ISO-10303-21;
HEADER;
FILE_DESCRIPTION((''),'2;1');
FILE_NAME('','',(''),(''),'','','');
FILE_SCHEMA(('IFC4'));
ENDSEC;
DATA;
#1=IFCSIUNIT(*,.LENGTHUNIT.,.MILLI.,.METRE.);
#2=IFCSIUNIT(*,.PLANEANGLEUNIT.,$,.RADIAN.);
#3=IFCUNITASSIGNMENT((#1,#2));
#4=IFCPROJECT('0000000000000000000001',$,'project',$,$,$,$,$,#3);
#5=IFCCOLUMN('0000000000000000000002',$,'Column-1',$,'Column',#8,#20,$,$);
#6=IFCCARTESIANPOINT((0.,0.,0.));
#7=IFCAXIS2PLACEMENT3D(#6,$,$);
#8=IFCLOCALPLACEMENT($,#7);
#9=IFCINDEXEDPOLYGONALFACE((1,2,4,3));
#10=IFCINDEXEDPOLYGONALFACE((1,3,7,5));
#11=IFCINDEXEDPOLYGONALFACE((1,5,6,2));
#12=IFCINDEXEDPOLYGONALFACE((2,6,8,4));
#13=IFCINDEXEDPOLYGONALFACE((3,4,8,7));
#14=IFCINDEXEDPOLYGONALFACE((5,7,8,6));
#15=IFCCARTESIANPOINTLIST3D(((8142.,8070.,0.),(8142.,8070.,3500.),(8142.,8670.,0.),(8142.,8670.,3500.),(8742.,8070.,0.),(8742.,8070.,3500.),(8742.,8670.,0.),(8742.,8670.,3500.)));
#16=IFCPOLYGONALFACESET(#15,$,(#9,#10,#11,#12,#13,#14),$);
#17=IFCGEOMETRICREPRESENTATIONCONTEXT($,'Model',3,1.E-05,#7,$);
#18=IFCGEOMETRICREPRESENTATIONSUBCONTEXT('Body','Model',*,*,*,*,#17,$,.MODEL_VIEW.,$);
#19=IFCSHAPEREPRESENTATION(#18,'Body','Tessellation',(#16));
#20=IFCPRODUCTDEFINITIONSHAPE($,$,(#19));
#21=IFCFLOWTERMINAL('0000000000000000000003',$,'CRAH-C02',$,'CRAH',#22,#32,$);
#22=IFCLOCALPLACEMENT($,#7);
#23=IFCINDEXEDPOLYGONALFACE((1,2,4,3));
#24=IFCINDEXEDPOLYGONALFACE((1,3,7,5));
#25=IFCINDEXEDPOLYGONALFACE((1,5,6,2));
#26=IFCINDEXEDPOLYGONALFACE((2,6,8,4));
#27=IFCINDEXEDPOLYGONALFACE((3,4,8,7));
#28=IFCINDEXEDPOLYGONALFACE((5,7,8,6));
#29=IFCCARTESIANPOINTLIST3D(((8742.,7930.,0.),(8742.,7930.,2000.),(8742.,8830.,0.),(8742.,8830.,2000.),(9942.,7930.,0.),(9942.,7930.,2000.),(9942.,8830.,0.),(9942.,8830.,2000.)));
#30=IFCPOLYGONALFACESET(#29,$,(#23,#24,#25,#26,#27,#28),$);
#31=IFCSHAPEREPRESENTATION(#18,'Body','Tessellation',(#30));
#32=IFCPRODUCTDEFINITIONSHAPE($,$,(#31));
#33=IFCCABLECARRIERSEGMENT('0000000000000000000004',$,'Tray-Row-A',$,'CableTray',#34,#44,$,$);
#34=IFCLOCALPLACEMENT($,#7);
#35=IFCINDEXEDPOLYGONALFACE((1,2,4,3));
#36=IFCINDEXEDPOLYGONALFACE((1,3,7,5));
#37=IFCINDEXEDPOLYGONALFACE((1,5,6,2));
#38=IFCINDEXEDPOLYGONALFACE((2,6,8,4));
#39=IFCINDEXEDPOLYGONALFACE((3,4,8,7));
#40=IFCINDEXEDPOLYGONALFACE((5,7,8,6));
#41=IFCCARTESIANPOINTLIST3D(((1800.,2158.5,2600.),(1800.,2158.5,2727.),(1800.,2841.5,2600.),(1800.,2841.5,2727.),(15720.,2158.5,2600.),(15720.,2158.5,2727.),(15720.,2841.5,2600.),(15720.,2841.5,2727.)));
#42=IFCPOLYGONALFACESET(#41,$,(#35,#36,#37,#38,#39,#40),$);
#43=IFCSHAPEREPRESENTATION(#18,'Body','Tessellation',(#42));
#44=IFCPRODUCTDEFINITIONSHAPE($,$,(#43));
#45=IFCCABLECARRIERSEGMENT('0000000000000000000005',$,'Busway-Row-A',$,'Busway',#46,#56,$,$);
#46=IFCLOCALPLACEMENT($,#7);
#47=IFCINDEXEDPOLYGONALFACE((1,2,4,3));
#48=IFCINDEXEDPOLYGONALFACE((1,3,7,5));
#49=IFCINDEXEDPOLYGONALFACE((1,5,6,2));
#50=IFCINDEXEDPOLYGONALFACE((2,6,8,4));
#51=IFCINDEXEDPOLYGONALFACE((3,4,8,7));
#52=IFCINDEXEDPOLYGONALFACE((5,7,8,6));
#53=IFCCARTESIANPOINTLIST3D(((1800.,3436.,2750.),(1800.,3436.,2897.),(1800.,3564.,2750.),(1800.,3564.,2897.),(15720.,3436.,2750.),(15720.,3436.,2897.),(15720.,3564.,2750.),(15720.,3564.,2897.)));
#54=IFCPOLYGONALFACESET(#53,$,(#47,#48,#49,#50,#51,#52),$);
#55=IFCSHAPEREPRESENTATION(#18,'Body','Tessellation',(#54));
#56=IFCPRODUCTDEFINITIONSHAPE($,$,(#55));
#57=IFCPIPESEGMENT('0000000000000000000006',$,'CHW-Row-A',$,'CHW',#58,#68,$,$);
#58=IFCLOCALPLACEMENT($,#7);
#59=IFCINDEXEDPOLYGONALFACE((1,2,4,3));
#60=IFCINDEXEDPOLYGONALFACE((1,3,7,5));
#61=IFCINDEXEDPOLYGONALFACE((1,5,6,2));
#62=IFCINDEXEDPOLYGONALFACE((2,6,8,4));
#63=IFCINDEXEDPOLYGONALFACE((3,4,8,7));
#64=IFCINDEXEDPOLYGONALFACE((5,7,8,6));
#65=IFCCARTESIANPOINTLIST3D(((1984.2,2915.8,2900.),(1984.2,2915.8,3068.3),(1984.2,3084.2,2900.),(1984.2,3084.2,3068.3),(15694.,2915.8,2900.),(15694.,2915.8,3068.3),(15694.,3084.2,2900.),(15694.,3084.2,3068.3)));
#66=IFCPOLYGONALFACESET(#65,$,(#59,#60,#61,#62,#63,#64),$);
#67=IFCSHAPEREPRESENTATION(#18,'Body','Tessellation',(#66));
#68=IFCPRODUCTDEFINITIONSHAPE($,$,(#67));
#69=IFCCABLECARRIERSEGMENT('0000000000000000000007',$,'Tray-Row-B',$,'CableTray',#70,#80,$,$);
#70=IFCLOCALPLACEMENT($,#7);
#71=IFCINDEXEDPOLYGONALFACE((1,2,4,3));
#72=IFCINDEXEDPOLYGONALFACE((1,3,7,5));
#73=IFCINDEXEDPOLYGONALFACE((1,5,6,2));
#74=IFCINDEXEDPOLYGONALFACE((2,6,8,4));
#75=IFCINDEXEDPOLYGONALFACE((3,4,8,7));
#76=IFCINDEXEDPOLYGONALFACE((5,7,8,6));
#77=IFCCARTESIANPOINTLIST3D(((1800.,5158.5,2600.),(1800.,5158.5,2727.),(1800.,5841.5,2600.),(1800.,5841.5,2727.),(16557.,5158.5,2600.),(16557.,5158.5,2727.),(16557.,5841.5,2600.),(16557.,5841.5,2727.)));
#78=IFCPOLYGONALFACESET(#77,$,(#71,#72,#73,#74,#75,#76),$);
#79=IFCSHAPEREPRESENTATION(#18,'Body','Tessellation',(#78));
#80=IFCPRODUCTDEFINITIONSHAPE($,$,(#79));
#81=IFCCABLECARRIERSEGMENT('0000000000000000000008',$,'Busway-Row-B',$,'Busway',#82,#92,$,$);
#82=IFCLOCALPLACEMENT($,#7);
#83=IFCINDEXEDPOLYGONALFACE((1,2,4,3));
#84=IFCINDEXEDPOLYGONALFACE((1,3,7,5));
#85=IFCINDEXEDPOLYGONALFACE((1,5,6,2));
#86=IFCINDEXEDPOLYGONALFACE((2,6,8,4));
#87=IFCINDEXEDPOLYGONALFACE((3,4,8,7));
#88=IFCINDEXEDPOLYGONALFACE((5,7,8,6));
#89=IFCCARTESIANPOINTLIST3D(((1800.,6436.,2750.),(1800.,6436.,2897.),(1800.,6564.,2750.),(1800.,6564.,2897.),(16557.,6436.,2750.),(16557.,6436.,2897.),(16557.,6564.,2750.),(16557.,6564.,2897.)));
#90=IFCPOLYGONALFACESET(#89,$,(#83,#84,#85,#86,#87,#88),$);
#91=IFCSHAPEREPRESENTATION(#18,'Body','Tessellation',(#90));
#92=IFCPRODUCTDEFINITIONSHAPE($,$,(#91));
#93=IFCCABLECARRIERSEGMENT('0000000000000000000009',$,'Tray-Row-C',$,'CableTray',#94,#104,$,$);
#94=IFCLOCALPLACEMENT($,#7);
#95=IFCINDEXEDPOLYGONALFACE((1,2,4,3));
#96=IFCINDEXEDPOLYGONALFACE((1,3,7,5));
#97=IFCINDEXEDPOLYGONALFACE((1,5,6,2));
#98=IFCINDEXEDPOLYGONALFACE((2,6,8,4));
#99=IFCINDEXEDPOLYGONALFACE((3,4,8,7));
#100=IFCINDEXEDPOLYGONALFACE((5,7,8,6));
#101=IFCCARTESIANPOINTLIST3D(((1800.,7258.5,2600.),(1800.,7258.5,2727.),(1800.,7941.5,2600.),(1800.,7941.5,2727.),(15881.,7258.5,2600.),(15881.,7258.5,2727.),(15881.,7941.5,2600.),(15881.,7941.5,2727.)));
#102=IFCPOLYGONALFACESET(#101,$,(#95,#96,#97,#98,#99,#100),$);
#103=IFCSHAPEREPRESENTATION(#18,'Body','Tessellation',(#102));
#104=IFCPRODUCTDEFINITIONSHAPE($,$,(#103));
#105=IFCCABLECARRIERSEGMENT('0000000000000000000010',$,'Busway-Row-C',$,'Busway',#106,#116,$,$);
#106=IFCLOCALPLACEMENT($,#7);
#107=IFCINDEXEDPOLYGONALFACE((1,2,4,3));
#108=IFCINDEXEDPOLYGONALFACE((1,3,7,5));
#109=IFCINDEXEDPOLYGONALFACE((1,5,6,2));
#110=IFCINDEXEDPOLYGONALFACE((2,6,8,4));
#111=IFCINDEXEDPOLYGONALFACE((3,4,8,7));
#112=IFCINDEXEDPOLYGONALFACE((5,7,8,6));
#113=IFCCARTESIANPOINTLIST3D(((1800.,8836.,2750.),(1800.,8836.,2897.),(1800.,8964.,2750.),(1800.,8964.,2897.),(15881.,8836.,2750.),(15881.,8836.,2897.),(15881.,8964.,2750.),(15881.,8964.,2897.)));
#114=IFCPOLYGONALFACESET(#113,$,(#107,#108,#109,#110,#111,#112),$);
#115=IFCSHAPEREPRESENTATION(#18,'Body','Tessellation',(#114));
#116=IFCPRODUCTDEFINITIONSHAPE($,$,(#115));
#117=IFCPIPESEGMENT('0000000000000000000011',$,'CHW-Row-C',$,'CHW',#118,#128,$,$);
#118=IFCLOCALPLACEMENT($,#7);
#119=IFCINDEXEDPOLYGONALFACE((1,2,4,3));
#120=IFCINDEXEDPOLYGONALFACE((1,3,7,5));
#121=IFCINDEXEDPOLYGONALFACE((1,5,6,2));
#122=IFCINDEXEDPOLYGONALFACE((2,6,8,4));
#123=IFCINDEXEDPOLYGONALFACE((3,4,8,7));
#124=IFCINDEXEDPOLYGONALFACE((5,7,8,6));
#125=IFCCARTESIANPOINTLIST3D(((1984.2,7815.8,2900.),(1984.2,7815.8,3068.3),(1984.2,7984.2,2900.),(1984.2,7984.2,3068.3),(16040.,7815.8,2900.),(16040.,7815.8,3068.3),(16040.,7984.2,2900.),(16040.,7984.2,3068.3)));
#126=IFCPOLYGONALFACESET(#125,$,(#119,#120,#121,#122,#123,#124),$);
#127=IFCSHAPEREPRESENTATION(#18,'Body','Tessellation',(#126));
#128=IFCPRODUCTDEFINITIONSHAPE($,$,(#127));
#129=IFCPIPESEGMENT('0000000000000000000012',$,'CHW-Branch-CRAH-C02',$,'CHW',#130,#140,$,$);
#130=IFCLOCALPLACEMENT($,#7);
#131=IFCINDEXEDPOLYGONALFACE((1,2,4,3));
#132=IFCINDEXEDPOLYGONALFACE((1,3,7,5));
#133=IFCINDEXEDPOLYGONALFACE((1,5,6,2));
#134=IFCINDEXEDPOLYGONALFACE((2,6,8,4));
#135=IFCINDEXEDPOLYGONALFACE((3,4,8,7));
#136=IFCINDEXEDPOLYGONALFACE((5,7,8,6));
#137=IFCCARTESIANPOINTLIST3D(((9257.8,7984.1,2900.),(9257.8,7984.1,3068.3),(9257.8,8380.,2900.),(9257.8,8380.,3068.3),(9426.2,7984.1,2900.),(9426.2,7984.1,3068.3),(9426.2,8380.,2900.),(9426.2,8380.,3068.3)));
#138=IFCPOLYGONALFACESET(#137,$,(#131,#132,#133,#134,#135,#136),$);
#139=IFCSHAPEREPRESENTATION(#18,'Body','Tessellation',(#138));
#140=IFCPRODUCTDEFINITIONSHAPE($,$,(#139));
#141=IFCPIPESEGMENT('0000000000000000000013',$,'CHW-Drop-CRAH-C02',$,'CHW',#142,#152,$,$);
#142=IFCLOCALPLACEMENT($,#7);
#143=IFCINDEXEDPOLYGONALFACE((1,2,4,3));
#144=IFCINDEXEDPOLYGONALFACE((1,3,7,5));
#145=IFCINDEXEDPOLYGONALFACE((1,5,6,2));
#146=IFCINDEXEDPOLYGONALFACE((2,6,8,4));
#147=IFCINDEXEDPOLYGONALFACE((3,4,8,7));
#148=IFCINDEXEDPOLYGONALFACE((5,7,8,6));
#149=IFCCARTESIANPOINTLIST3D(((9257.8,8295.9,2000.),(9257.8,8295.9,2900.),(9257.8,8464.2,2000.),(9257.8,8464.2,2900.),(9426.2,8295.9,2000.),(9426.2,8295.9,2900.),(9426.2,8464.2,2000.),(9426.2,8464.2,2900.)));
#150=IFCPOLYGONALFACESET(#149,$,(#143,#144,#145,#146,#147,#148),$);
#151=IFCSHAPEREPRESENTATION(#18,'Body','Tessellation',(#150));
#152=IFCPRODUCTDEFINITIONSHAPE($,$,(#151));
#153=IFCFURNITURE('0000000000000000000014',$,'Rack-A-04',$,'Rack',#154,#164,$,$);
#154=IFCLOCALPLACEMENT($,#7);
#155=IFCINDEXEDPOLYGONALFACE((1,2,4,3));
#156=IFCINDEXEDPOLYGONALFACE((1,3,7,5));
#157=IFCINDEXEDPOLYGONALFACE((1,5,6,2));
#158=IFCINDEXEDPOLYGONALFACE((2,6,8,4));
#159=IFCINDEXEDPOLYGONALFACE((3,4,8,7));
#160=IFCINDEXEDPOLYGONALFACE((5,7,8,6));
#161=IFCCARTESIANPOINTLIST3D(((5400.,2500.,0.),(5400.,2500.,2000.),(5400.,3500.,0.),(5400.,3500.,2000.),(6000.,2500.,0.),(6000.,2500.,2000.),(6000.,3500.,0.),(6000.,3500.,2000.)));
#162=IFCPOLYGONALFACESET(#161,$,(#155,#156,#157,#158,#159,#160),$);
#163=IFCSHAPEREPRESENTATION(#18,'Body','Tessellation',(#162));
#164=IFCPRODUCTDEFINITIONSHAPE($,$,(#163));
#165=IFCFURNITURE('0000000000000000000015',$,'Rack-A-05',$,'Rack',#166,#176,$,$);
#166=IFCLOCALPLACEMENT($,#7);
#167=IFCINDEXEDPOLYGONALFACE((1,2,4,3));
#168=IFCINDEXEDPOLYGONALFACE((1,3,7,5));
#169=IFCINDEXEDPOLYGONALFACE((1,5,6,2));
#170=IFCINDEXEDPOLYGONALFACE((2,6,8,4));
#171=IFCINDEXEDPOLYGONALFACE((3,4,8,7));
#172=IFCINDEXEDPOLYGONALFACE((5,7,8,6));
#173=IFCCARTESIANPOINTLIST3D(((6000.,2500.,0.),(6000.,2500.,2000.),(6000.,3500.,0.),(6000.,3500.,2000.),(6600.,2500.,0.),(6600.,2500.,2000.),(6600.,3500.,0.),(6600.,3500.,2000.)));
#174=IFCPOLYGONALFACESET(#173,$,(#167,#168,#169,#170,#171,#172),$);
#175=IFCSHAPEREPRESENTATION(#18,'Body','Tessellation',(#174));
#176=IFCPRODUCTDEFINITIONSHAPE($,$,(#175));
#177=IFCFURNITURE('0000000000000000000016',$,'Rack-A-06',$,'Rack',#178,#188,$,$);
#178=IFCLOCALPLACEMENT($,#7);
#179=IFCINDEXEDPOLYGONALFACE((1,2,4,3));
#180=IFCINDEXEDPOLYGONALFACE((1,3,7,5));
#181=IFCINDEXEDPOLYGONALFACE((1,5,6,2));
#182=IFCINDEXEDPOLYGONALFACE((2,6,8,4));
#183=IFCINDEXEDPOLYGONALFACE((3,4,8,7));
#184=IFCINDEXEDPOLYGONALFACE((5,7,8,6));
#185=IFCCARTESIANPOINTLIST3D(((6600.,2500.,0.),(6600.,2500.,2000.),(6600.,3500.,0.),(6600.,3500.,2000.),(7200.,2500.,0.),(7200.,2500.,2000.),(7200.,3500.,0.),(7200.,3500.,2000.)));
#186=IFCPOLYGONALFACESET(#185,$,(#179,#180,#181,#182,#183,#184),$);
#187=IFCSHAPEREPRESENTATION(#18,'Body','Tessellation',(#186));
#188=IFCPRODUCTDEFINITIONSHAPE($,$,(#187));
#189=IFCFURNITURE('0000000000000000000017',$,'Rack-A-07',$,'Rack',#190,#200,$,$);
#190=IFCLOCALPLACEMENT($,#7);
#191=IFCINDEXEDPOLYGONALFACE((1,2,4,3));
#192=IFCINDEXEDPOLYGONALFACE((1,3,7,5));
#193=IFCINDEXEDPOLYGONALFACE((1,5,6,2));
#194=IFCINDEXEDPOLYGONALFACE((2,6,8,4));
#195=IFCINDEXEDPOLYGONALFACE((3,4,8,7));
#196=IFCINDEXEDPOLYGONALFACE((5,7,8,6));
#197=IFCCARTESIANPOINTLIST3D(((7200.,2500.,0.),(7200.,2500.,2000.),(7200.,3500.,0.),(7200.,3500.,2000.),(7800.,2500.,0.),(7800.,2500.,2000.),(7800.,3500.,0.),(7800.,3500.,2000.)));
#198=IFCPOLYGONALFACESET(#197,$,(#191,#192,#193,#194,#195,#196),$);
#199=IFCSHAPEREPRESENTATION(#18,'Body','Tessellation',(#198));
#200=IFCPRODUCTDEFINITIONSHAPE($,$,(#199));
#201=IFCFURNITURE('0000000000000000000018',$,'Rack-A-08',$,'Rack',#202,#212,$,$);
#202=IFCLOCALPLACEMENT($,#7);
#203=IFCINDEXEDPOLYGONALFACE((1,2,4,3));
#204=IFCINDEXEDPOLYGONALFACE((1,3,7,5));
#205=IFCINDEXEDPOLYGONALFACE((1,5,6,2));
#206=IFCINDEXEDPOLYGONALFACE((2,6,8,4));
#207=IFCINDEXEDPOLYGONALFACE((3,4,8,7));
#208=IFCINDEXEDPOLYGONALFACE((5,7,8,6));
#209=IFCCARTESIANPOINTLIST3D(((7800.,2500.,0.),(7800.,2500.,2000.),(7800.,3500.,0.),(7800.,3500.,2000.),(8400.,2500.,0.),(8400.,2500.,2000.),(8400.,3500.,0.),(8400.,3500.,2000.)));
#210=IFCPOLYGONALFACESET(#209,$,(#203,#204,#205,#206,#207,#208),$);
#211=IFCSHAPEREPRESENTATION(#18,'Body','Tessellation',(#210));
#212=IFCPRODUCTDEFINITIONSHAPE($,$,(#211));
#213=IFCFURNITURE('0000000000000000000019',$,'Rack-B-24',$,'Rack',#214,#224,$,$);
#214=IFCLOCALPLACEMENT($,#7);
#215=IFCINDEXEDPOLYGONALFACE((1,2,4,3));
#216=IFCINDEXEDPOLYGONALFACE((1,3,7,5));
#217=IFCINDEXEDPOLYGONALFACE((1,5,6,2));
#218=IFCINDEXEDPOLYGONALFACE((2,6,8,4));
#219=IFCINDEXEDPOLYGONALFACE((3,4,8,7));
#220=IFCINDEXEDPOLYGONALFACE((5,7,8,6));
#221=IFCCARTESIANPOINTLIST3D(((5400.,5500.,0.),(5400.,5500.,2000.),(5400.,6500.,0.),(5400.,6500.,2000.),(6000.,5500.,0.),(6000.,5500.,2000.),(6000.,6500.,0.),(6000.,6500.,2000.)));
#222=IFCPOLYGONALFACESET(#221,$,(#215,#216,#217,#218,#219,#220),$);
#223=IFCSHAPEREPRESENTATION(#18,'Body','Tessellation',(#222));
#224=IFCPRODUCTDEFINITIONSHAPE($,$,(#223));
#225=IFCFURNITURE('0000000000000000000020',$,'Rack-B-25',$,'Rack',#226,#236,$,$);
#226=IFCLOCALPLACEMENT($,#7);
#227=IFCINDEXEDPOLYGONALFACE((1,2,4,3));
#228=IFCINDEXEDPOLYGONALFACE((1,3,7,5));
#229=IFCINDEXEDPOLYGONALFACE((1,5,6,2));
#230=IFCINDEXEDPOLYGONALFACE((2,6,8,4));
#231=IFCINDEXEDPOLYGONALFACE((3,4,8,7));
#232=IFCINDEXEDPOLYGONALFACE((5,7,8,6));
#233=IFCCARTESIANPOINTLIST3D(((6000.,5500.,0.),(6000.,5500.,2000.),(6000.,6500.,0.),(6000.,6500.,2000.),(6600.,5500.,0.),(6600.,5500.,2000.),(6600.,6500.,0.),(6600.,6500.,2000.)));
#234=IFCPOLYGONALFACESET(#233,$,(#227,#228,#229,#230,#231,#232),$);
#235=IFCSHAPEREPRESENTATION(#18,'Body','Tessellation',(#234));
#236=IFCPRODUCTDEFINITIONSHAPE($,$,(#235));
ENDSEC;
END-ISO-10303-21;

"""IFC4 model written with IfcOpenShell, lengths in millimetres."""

from ifc_helpers import new_model, si_unit, frame, origin, place, context, subcontext, project, rectangle, extrude, element, save


model = new_model("IFC4")

# Units and contexts
model_context = context("Model", 3, precision=1e-05, world=origin())
body_context = subcontext(model_context, "Body", "Model", "MODEL_VIEW")
ifc_project = project(units=[si_unit("LENGTHUNIT", "METRE", prefix="MILLI"), si_unit("PLANEANGLEUNIT", "RADIAN")])

# Column
column_placement = place(None, frame((8442.0, 8370.0, 0.0)))
element("IfcColumn", 1, at=column_placement, Name="Column-1", ObjectType="Column", context=body_context, shape_type="SweptSolid", body=[
    extrude(rectangle(XDim=600.0, YDim=600.0), None, (0.0, 0.0, 1.0), 3500.0),
])

# Flow terminal
flow_terminal_placement = place(None, frame((9342.0, 8380.0, 0.0)))
element("IfcFlowTerminal", 2, at=flow_terminal_placement, Name="CRAH-C02", ObjectType="CRAH", context=body_context, shape_type="SweptSolid", body=[
    extrude(rectangle(XDim=1200.0, YDim=900.0), None, (0.0, 0.0, 1.0), 2000.0),
])

# Cable carrier segments
cable_carrier_segment_1_placement = place(None, frame((8760.0, 2500.0, 2600.0)))
element("IfcCableCarrierSegment", 3, at=cable_carrier_segment_1_placement, Name="Tray-Row-A", ObjectType="CableTray", context=body_context, shape_type="SweptSolid", body=[
    extrude(rectangle(XDim=13920.0, YDim=683.0), None, (0.0, 0.0, 1.0), 127.0),
])
cable_carrier_segment_2_placement = place(None, frame((8760.0, 3500.0, 2750.0)))
element("IfcCableCarrierSegment", 4, at=cable_carrier_segment_2_placement, Name="Busway-Row-A", ObjectType="Busway", context=body_context, shape_type="SweptSolid", body=[
    extrude(rectangle(XDim=13920.0, YDim=128.0), None, (0.0, 0.0, 1.0), 147.0),
])

# Pipe segment
pipe_segment_1_placement = place(None, frame((8839.1, 3000.0, 2900.0)))
element("IfcPipeSegment", 5, at=pipe_segment_1_placement, Name="CHW-Row-A", ObjectType="CHW", context=body_context, shape_type="SweptSolid", body=[
    extrude(rectangle(XDim=13709.9, YDim=168.3), None, (0.0, 0.0, 1.0), 168.3),
])

# Cable carrier segments
cable_carrier_segment_3_placement = place(None, frame((9178.5, 5500.0, 2600.0)))
element("IfcCableCarrierSegment", 6, at=cable_carrier_segment_3_placement, Name="Tray-Row-B", ObjectType="CableTray", context=body_context, shape_type="SweptSolid", body=[
    extrude(rectangle(XDim=14757.0, YDim=683.0), None, (0.0, 0.0, 1.0), 127.0),
])
cable_carrier_segment_4_placement = place(None, frame((9178.5, 6500.0, 2750.0)))
element("IfcCableCarrierSegment", 7, at=cable_carrier_segment_4_placement, Name="Busway-Row-B", ObjectType="Busway", context=body_context, shape_type="SweptSolid", body=[
    extrude(rectangle(XDim=14757.0, YDim=128.0), None, (0.0, 0.0, 1.0), 147.0),
])
cable_carrier_segment_5_placement = place(None, frame((8840.5, 7600.0, 2600.0)))
element("IfcCableCarrierSegment", 8, at=cable_carrier_segment_5_placement, Name="Tray-Row-C", ObjectType="CableTray", context=body_context, shape_type="SweptSolid", body=[
    extrude(rectangle(XDim=14081.0, YDim=683.0), None, (0.0, 0.0, 1.0), 127.0),
])
cable_carrier_segment_6_placement = place(None, frame((8840.5, 8900.0, 2750.0)))
element("IfcCableCarrierSegment", 9, at=cable_carrier_segment_6_placement, Name="Busway-Row-C", ObjectType="Busway", context=body_context, shape_type="SweptSolid", body=[
    extrude(rectangle(XDim=14081.0, YDim=128.0), None, (0.0, 0.0, 1.0), 147.0),
])

# Pipe segments
pipe_segment_2_placement = place(None, frame((9012.1, 7900.0, 2900.0)))
element("IfcPipeSegment", 10, at=pipe_segment_2_placement, Name="CHW-Row-C", ObjectType="CHW", context=body_context, shape_type="SweptSolid", body=[
    extrude(rectangle(XDim=14055.9, YDim=168.3), None, (0.0, 0.0, 1.0), 168.3),
])
pipe_segment_3_placement = place(None, frame((9342.0, 8182.1, 2900.0)))
element("IfcPipeSegment", 11, at=pipe_segment_3_placement, Name="CHW-Branch-CRAH-C02", ObjectType="CHW", context=body_context, shape_type="SweptSolid", body=[
    extrude(rectangle(XDim=168.3, YDim=395.9), None, (0.0, 0.0, 1.0), 168.3),
])
pipe_segment_4_placement = place(None, frame((9342.0, 8380.0, 2000.0)))
element("IfcPipeSegment", 12, at=pipe_segment_4_placement, Name="CHW-Drop-CRAH-C02", ObjectType="CHW", context=body_context, shape_type="SweptSolid", body=[
    extrude(rectangle(XDim=168.3, YDim=168.3), None, (0.0, 0.0, 1.0), 900.0),
])

# Furniture
for number, where, name in (
    (13, (5700.0, 3000.0, 0.0), "Rack-A-04"),
    (14, (6300.0, 3000.0, 0.0), "Rack-A-05"),
    (15, (6900.0, 3000.0, 0.0), "Rack-A-06"),
    (16, (7500.0, 3000.0, 0.0), "Rack-A-07"),
    (17, (8100.0, 3000.0, 0.0), "Rack-A-08"),
    (18, (5700.0, 6000.0, 0.0), "Rack-B-24"),
    (19, (6300.0, 6000.0, 0.0), "Rack-B-25"),
):
    element("IfcFurniture", number, at=place(None, frame(where)), Name=name, ObjectType="Rack", context=body_context, shape_type="SweptSolid", body=[
        extrude(rectangle(XDim=600.0, YDim=1000.0), None, (0.0, 0.0, 1.0), 2000.0),
    ])

save(model, "model.ifc")
